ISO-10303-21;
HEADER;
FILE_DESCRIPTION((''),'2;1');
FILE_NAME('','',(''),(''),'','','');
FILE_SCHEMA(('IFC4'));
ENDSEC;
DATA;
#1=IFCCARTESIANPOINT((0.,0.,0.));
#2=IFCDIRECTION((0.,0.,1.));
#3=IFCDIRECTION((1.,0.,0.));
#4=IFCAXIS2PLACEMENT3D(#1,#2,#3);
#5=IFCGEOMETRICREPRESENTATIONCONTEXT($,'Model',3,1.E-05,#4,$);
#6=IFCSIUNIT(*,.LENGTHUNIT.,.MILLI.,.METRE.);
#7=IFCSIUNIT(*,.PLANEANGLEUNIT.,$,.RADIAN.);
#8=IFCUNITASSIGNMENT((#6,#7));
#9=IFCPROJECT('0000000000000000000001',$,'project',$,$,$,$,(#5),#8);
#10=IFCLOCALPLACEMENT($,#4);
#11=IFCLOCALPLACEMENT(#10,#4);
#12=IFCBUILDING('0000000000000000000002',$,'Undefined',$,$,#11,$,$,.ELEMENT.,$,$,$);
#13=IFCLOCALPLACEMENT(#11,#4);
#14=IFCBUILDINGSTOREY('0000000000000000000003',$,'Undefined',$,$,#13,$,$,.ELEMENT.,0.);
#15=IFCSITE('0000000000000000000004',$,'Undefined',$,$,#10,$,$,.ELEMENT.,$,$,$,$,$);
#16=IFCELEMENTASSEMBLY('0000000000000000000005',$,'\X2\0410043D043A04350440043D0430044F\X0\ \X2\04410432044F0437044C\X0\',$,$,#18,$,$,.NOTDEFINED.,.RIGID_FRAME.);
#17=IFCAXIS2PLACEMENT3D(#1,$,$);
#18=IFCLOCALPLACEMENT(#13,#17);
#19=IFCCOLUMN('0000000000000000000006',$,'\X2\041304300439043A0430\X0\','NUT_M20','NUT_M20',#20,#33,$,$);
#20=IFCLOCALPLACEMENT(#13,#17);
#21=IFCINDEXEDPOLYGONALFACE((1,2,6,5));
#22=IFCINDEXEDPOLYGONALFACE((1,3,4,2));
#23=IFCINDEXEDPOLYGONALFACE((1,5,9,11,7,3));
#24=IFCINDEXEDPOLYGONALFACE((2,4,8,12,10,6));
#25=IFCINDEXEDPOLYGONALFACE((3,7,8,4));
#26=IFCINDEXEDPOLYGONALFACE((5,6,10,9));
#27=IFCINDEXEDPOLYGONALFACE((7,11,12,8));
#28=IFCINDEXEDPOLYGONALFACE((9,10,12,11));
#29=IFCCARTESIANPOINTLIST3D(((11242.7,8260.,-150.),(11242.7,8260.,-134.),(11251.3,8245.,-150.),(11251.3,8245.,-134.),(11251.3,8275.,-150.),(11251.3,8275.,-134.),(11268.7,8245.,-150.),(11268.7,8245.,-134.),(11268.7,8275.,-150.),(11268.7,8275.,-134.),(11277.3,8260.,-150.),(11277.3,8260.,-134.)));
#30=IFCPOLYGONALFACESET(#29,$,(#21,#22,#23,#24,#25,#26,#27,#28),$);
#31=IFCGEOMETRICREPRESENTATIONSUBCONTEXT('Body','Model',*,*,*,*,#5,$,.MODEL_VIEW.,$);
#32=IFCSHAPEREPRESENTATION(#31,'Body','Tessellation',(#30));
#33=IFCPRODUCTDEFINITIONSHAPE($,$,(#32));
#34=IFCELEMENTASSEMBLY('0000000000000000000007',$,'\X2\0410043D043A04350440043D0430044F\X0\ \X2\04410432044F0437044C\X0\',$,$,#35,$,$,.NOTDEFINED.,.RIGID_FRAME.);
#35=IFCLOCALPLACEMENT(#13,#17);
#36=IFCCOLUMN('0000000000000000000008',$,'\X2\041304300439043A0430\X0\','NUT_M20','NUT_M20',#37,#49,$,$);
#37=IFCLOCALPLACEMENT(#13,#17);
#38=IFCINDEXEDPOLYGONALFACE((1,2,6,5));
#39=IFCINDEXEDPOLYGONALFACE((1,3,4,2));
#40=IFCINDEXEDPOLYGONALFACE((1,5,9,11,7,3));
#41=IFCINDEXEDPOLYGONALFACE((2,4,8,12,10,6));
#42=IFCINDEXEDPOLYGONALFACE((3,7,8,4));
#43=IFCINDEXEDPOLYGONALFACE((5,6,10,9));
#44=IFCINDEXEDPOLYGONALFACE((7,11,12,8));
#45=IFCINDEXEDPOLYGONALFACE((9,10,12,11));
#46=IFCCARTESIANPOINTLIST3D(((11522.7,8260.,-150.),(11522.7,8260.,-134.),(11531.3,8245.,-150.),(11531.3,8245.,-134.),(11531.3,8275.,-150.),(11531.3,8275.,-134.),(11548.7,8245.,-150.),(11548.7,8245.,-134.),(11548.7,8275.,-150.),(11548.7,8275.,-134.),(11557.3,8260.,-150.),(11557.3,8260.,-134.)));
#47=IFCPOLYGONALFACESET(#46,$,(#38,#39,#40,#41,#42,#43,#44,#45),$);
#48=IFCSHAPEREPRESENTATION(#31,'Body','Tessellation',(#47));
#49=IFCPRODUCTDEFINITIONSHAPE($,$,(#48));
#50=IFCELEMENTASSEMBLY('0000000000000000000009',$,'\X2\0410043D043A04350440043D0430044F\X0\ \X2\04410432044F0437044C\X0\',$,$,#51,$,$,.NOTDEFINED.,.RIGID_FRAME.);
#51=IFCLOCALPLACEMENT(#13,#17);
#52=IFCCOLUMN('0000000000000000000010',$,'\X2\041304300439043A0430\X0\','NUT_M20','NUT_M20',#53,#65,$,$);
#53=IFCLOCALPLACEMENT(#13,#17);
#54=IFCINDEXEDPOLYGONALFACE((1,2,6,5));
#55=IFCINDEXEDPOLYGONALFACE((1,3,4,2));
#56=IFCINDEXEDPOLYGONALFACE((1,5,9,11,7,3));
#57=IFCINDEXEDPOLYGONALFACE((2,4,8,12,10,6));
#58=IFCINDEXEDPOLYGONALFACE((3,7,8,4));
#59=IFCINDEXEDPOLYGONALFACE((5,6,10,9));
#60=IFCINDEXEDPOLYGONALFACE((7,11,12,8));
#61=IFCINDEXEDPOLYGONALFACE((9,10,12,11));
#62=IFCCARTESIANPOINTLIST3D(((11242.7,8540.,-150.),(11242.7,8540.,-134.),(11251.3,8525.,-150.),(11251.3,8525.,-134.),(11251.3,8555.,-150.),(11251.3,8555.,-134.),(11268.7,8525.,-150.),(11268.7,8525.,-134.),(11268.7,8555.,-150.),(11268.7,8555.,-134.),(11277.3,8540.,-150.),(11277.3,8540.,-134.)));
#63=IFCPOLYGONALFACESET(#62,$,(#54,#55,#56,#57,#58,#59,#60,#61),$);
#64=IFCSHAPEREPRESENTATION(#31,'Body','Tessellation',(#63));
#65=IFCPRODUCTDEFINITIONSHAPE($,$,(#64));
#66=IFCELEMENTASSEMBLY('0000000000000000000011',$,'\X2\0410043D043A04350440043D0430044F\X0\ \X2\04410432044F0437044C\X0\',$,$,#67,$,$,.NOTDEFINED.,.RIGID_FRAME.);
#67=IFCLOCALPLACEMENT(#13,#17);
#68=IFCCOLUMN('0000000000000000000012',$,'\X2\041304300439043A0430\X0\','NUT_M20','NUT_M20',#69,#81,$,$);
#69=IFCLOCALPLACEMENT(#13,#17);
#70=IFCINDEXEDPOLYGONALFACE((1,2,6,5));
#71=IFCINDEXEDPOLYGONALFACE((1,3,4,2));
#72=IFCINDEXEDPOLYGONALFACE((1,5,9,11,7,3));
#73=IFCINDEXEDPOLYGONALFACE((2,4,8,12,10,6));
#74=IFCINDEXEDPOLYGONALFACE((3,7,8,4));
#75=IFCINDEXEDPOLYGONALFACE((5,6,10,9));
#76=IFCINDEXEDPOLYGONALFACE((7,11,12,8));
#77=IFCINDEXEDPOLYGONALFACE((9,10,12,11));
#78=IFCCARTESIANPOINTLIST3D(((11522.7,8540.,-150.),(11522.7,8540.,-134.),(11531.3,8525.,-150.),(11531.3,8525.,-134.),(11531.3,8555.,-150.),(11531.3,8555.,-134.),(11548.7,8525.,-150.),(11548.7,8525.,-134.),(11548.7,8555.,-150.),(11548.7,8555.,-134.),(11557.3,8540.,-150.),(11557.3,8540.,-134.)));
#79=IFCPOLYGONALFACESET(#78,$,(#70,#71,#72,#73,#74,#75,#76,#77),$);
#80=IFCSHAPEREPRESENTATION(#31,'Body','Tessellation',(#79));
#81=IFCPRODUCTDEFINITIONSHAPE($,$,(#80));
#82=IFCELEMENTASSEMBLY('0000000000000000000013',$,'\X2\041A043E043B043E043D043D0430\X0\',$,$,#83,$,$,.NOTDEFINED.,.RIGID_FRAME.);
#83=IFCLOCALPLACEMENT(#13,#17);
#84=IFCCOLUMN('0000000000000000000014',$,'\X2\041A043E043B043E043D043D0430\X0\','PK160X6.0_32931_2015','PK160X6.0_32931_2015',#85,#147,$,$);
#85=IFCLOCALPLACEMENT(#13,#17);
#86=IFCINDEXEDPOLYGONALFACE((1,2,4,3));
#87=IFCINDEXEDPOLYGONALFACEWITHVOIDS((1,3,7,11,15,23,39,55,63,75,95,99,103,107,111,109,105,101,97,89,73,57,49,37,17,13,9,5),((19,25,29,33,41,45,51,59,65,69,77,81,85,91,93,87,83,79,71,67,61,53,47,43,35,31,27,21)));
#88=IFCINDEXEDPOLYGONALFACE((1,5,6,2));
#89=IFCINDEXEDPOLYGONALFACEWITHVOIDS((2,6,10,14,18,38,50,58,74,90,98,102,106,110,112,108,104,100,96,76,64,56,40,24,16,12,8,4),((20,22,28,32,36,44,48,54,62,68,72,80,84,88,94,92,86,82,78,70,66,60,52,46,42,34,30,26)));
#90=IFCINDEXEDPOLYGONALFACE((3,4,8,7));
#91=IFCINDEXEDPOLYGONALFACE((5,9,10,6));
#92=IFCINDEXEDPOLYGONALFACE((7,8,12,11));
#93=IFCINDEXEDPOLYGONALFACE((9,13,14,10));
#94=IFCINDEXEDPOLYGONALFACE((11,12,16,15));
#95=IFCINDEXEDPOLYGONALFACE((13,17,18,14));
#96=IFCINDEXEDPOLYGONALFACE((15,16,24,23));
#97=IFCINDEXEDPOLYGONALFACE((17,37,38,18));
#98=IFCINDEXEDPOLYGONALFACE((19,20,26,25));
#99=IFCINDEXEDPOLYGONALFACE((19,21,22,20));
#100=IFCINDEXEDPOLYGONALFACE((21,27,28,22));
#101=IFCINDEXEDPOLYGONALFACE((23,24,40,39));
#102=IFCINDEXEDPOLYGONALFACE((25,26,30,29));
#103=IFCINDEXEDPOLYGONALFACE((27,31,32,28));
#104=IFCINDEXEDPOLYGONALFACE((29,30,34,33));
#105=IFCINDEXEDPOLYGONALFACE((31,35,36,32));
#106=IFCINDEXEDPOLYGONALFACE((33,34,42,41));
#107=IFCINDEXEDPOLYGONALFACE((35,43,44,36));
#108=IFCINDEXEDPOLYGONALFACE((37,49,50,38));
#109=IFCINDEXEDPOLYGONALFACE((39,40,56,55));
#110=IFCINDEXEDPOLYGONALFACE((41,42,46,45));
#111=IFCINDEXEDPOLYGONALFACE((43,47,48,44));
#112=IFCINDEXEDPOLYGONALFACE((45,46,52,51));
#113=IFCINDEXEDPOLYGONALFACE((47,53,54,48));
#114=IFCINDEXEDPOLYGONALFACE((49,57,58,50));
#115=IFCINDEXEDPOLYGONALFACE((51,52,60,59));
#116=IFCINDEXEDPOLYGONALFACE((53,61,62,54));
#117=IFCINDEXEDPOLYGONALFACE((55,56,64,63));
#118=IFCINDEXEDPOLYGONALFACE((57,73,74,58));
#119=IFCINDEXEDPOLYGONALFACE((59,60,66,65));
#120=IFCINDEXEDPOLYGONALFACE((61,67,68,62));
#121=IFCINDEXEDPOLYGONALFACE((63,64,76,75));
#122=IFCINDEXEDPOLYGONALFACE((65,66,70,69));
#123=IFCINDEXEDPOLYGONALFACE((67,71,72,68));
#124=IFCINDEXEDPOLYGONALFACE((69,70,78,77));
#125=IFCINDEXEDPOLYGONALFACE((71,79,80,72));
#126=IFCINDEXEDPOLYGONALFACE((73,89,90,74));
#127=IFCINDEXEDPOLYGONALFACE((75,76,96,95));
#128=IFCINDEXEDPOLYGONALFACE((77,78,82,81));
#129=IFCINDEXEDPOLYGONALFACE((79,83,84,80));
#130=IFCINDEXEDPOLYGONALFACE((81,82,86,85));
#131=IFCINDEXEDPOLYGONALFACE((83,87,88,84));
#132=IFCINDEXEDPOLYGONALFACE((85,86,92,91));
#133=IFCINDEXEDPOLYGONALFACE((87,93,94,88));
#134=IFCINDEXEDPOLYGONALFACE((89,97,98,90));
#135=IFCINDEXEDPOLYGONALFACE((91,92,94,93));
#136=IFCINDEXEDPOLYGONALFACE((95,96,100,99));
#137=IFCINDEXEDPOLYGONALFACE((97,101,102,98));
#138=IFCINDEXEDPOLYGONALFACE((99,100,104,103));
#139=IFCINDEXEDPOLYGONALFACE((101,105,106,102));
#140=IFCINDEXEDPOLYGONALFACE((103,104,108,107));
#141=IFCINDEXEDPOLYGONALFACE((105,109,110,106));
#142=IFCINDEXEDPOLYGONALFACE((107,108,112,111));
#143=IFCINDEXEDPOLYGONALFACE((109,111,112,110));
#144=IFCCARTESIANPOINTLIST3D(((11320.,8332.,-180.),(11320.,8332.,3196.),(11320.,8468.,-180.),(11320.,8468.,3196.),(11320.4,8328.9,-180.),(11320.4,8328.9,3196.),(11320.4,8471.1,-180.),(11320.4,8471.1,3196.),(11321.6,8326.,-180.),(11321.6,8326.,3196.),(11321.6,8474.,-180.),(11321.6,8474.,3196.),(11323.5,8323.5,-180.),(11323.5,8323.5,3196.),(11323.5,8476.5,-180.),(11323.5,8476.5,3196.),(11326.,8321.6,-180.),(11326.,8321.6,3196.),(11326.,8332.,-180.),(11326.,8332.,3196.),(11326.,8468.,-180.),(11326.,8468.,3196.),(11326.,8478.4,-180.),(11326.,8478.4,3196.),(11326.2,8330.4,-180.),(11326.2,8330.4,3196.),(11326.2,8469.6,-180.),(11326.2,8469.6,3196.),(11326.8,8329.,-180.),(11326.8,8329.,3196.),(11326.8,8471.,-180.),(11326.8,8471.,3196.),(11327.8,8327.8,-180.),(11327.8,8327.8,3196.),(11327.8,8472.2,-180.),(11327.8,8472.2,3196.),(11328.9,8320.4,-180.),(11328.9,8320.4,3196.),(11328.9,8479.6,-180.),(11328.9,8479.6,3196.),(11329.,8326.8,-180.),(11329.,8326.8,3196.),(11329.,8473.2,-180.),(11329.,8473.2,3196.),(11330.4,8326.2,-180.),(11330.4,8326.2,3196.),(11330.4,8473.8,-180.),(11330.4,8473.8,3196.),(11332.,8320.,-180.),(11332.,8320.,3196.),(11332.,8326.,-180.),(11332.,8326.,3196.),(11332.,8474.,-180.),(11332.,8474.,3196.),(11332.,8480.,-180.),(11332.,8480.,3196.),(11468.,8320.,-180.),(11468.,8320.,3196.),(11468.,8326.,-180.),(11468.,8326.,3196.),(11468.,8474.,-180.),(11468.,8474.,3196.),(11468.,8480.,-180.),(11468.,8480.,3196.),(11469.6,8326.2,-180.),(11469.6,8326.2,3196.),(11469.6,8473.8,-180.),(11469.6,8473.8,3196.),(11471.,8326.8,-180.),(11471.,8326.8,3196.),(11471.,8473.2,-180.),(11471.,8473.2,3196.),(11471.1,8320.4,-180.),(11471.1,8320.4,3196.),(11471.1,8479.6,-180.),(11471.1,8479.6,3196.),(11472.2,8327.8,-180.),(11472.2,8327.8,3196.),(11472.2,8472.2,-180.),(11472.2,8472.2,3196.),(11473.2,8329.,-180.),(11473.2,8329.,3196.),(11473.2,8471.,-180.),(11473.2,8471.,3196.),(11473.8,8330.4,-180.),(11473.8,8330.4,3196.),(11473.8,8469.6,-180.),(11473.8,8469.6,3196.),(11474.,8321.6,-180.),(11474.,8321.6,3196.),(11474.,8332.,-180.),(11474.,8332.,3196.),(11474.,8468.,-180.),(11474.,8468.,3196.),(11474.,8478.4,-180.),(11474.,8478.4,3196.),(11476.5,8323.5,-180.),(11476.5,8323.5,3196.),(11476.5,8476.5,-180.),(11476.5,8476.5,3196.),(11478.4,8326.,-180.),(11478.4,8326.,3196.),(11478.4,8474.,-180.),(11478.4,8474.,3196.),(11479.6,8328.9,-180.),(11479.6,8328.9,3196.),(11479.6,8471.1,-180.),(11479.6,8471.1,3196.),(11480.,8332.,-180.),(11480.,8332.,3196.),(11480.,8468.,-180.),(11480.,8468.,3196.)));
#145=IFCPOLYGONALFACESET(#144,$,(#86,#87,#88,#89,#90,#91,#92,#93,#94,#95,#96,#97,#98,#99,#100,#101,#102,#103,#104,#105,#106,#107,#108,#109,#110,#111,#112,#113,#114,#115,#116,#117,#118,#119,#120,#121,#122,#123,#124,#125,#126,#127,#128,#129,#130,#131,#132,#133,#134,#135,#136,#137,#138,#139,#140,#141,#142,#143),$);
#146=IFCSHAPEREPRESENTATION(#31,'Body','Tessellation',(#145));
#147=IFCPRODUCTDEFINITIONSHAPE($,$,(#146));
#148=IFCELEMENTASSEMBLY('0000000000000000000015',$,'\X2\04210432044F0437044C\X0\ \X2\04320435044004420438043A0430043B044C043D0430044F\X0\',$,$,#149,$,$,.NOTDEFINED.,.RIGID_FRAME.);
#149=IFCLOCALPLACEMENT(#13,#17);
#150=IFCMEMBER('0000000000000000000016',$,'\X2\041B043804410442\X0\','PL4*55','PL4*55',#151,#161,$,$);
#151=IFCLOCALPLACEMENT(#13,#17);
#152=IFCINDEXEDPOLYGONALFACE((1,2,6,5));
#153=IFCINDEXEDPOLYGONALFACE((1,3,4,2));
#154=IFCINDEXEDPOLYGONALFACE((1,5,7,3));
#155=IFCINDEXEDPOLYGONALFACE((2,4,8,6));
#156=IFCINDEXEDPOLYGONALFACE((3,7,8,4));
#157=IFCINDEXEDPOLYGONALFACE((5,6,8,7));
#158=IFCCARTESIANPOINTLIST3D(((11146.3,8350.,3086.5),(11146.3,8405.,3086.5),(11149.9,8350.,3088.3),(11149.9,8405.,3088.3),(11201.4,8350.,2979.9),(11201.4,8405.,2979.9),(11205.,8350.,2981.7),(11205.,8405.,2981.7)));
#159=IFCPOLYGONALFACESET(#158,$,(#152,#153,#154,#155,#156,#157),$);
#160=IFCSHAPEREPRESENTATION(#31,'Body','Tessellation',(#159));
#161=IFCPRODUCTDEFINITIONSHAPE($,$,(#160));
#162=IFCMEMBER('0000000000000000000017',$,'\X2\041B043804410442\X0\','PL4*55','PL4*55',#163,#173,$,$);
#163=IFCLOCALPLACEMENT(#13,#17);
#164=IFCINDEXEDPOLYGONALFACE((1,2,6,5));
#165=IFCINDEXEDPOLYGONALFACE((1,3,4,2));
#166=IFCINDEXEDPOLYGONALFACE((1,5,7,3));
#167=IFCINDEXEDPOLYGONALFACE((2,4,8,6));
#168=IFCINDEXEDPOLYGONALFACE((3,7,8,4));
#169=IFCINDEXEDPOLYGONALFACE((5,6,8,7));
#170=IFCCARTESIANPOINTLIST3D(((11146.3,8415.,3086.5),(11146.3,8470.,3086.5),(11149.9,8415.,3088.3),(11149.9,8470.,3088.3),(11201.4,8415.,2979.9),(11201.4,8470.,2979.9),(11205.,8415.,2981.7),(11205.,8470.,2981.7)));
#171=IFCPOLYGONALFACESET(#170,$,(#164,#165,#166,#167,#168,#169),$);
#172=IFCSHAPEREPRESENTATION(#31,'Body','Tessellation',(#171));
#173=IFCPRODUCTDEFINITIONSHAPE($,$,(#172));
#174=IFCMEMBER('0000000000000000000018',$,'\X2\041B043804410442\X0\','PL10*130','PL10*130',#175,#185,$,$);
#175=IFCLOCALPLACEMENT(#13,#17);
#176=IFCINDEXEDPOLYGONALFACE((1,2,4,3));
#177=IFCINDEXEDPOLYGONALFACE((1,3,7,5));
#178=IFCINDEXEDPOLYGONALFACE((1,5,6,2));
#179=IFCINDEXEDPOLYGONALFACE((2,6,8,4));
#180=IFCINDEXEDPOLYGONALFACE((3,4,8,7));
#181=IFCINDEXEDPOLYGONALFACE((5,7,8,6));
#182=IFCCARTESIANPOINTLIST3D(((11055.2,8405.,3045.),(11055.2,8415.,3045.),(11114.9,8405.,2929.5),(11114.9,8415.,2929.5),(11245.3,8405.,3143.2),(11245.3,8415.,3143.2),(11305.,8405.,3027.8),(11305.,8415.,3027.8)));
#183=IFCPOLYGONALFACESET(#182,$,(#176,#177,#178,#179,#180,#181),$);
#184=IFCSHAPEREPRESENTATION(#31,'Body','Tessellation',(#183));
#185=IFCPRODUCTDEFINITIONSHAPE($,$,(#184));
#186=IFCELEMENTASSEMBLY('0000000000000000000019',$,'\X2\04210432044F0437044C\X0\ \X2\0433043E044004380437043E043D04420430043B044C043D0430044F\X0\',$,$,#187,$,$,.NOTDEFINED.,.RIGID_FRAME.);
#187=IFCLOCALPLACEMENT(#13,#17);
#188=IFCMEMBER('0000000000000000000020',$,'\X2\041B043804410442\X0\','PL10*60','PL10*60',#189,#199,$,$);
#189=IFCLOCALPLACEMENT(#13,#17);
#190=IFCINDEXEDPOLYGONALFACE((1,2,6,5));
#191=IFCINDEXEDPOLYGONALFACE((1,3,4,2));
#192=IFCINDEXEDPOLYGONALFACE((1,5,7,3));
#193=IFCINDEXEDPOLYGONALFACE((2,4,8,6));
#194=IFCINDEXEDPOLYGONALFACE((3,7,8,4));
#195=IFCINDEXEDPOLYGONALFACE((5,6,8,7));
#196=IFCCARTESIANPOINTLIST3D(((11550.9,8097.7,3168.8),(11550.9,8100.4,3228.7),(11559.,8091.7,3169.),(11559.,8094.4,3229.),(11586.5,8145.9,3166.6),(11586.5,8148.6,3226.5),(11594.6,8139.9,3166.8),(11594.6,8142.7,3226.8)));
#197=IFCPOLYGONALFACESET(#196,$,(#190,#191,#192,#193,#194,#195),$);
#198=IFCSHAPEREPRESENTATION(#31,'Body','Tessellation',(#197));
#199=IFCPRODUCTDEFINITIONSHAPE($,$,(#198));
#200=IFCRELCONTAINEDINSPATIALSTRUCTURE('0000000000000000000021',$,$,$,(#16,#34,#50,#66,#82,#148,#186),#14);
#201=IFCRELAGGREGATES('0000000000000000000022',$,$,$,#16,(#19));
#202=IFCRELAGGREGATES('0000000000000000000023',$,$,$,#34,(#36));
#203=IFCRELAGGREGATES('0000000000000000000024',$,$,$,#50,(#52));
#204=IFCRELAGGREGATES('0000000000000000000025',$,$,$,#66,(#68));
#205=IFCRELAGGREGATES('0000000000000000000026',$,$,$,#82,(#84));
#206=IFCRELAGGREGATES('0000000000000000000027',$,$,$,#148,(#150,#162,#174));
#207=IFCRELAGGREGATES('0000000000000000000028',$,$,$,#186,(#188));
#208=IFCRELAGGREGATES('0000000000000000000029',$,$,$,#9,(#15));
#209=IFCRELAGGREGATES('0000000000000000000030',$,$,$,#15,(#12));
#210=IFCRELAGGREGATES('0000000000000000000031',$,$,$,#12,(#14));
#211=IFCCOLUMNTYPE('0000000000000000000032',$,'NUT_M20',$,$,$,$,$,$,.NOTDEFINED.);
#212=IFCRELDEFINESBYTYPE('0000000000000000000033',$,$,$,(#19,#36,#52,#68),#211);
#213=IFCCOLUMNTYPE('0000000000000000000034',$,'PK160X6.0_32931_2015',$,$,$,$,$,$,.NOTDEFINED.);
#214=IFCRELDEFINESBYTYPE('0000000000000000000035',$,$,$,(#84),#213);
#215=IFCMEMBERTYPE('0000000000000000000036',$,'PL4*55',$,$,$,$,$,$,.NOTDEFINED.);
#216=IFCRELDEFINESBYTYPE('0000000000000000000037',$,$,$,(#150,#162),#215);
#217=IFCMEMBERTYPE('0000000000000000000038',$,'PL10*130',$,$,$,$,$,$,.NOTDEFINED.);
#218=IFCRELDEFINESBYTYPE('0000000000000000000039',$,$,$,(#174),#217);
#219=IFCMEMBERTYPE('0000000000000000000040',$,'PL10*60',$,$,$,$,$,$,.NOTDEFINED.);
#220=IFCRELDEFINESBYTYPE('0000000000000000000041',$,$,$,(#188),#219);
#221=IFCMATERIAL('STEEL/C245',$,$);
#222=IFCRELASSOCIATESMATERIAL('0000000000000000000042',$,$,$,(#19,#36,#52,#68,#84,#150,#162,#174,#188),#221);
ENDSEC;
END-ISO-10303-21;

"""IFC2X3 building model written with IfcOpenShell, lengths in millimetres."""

from ifc_helpers import new_model, si_unit, frame, origin_with_axes, origin_2d_with_axis, place, context, subcontext, project, spatial, polyline, rectangle, hollow_rectangle, outline, extrude, clip, halfspace, material, type_object, element, aggregate, save


model = new_model("IFC2X3")

# Units and contexts
model_context = context("Model", 3, precision=1e-05, world=origin_with_axes())
body_context = subcontext(model_context, "Body", "Model", "MODEL_VIEW")
ifc_project = project(units=[si_unit("LENGTHUNIT", "METRE", prefix="MILLI"), si_unit("PLANEANGLEUNIT", "RADIAN")], contexts=[model_context])

# Site, building, storey
site_placement = place(None, origin_with_axes())
site = spatial("IfcSite", under=ifc_project, at=site_placement, Name="Undefined", CompositionType="ELEMENT")
building_placement = place(site_placement, origin_with_axes())
building = spatial("IfcBuilding", under=site, at=building_placement, Name="Undefined", CompositionType="ELEMENT")
storey_placement = place(building_placement, origin_with_axes())
storey = spatial("IfcBuildingStorey", under=building, at=storey_placement, Name="Undefined", CompositionType="ELEMENT", Elevation=0.0)

# Element assemblies, columns
assembly_1_placement = place(storey_placement, origin_with_axes())
assembly_1 = element("IfcElementAssembly", 1, at=assembly_1_placement, inside=storey, Name="Анкерная связь", AssemblyPlace="NOTDEFINED", PredefinedType="RIGID_FRAME")
ifc_material_1 = material(Name="STEEL/C245")
column_type_1 = type_object("IfcColumnType", Name="NUT_M20", PredefinedType="NOTDEFINED")
column_1_placement = place(assembly_1_placement, frame((11260.0, 8260.0, -134.0), z_axis=(0.0, 0.0, -1.0), x_axis=(0.0, -1.0, 0.0)))
column_1 = element("IfcColumn", 2, at=column_1_placement, type_object=column_type_1, material=ifc_material_1, Name="Гайка", Description="NUT_M20", ObjectType="NUT_M20", context=body_context, shape_type="SweptSolid", body=[
    extrude(outline(polyline([(8.7, -15.0), (-8.7, -15.0), (-17.3, 0.0), (-8.7, 15.0), (8.7, 15.0), (17.3, 0.0), (8.7, -15.0)])), frame((0.0, 0.0, 16.0), z_axis=(0.0, 0.0, -1.0), x_axis=(0.0, 1.0, 0.0)), (0.0, 0.0, 1.0), 16.0),
])
aggregate(assembly_1, [column_1])
assembly_2_placement = place(storey_placement, origin_with_axes())
assembly_2 = element("IfcElementAssembly", 3, at=assembly_2_placement, inside=storey, Name="Анкерная связь", AssemblyPlace="NOTDEFINED", PredefinedType="RIGID_FRAME")
column_2_placement = place(assembly_2_placement, frame((11540.0, 8260.0, -134.0), z_axis=(0.0, 0.0, -1.0), x_axis=(0.0, 1.0, 0.0)))
column_2 = element("IfcColumn", 4, at=column_2_placement, type_object=column_type_1, material=ifc_material_1, Name="Гайка", Description="NUT_M20", ObjectType="NUT_M20", context=body_context, shape_type="SweptSolid", body=[
    extrude(outline(polyline([(8.7, -15.0), (-8.7, -15.0), (-17.3, 0.0), (-8.7, 15.0), (8.7, 15.0), (17.3, 0.0), (8.7, -15.0)])), frame((0.0, 0.0, 16.0), z_axis=(0.0, 0.0, -1.0), x_axis=(0.0, 1.0, 0.0)), (0.0, 0.0, 1.0), 16.0),
])
aggregate(assembly_2, [column_2])
assembly_3_placement = place(storey_placement, origin_with_axes())
assembly_3 = element("IfcElementAssembly", 5, at=assembly_3_placement, inside=storey, Name="Анкерная связь", AssemblyPlace="NOTDEFINED", PredefinedType="RIGID_FRAME")
column_3_placement = place(assembly_3_placement, frame((11260.0, 8540.0, -134.0), z_axis=(0.0, 0.0, -1.0), x_axis=(0.0, -1.0, 0.0)))
column_3 = element("IfcColumn", 6, at=column_3_placement, type_object=column_type_1, material=ifc_material_1, Name="Гайка", Description="NUT_M20", ObjectType="NUT_M20", context=body_context, shape_type="SweptSolid", body=[
    extrude(outline(polyline([(8.7, -15.0), (-8.7, -15.0), (-17.3, 0.0), (-8.7, 15.0), (8.7, 15.0), (17.3, 0.0), (8.7, -15.0)])), frame((0.0, 0.0, 16.0), z_axis=(0.0, 0.0, -1.0), x_axis=(0.0, 1.0, 0.0)), (0.0, 0.0, 1.0), 16.0),
])
aggregate(assembly_3, [column_3])
assembly_4_placement = place(storey_placement, origin_with_axes())
assembly_4 = element("IfcElementAssembly", 7, at=assembly_4_placement, inside=storey, Name="Анкерная связь", AssemblyPlace="NOTDEFINED", PredefinedType="RIGID_FRAME")
column_4_placement = place(assembly_4_placement, frame((11540.0, 8540.0, -134.0), z_axis=(0.0, 0.0, -1.0), x_axis=(0.0, 1.0, 0.0)))
column_4 = element("IfcColumn", 8, at=column_4_placement, type_object=column_type_1, material=ifc_material_1, Name="Гайка", Description="NUT_M20", ObjectType="NUT_M20", context=body_context, shape_type="SweptSolid", body=[
    extrude(outline(polyline([(8.7, -15.0), (-8.7, -15.0), (-17.3, 0.0), (-8.7, 15.0), (8.7, 15.0), (17.3, 0.0), (8.7, -15.0)])), frame((0.0, 0.0, 16.0), z_axis=(0.0, 0.0, -1.0), x_axis=(0.0, 1.0, 0.0)), (0.0, 0.0, 1.0), 16.0),
])
aggregate(assembly_4, [column_4])
assembly_5_placement = place(storey_placement, origin_with_axes())
assembly_5 = element("IfcElementAssembly", 9, at=assembly_5_placement, inside=storey, Name="Колонна", AssemblyPlace="NOTDEFINED", PredefinedType="RIGID_FRAME")
column_type_2 = type_object("IfcColumnType", Name="PK160X6.0_32931_2015", PredefinedType="NOTDEFINED")
column_5_placement = place(assembly_5_placement, frame((11400.0, 8400.0, -40.0), z_axis=(0.0, 0.0, 1.0), x_axis=(0.0, 1.0, 0.0)))
column_5 = element("IfcColumn", 10, at=column_5_placement, type_object=column_type_2, material=ifc_material_1, Name="Колонна", Description="PK160X6.0_32931_2015", ObjectType="PK160X6.0_32931_2015", context=body_context, shape_type="Clipping", body=[
    clip(clip(extrude(hollow_rectangle(XDim=160.0, YDim=160.0, WallThickness=6.0, InnerFilletRadius=6.0, OuterFilletRadius=12.0, at=origin_2d_with_axis()), frame((0.0, 0.0, 3236.0), z_axis=(0.0, 0.0, -1.0), x_axis=(0.0, 1.0, 0.0)), (0.0, 0.0, 1.0), 3376.0), halfspace(frame((-80.0, 0.0, 3236.0), z_axis=(0.0, 0.0, -1.0), x_axis=(0.0, -1.0, 0.0)), True)), halfspace(frame((-80.0, 0.0, -140.0), z_axis=(0.0, 0.0, 1.0), x_axis=(0.0, 1.0, 0.0)), True)),
])

# Element assembly, members
assembly_6_placement = place(storey_placement, origin_with_axes())
assembly_6 = element("IfcElementAssembly", 11, at=assembly_6_placement, inside=storey, Name="Связь вертикальная", AssemblyPlace="NOTDEFINED", PredefinedType="RIGID_FRAME")
member_type_1 = type_object("IfcMemberType", Name="PL4*55", PredefinedType="NOTDEFINED")
member_1_placement = place(assembly_6_placement, frame((11203.2, 8377.5, 2980.8), z_axis=(0.0, 1.0, 0.0), x_axis=(-0.45902, 0.0, 0.888426)))
member_1 = element("IfcMember", 12, at=member_1_placement, type_object=member_type_1, material=ifc_material_1, Name="Лист", Description="PL4*55", ObjectType="PL4*55", context=body_context, shape_type="SweptSolid", body=[
    extrude(rectangle(XDim=4.0, YDim=55.0, at=origin_2d_with_axis()), frame((120.0, 0.0, 0.0), z_axis=(-1.0, 0.0, 0.0), x_axis=(0.0, -1.0, 0.0)), (0.0, 0.0, 1.0), 120.0),
])
member_2_placement = place(assembly_6_placement, frame((11203.2, 8442.5, 2980.8), z_axis=(0.0, -1.0, 0.0), x_axis=(-0.45902, 0.0, 0.888426)))
member_2 = element("IfcMember", 13, at=member_2_placement, type_object=member_type_1, material=ifc_material_1, Name="Лист", Description="PL4*55", ObjectType="PL4*55", context=body_context, shape_type="SweptSolid", body=[
    extrude(rectangle(XDim=4.0, YDim=55.0, at=origin_2d_with_axis()), frame((120.0, 0.0, 0.0), z_axis=(-1.0, 0.0, 0.0), x_axis=(0.0, -1.0, 0.0)), (0.0, 0.0, 1.0), 120.0),
])
member_type_2 = type_object("IfcMemberType", Name="PL10*130", PredefinedType="NOTDEFINED")
member_3_placement = place(assembly_6_placement, frame((11275.2, 8410.0, 3085.5), z_axis=(0.45902, 0.0, -0.888426), x_axis=(-0.888426, 0.0, -0.45902)))
member_3 = element("IfcMember", 14, at=member_3_placement, type_object=member_type_2, material=ifc_material_1, Name="Лист", Description="PL10*130", ObjectType="PL10*130", context=body_context, shape_type="SweptSolid", body=[
    extrude(rectangle(XDim=10.0, YDim=130.0, at=origin_2d_with_axis()), frame((214.0, 0.0, 0.0), z_axis=(-1.0, 0.0, 0.0), x_axis=(0.0, -1.0, 0.0)), (0.0, 0.0, 1.0), 214.0),
])

# Element assembly, member
assembly_7_placement = place(storey_placement, origin_with_axes())
assembly_7 = element("IfcElementAssembly", 15, at=assembly_7_placement, inside=storey, Name="Связь горизонтальная", AssemblyPlace="NOTDEFINED", PredefinedType="RIGID_FRAME")
member_type_3 = type_object("IfcMemberType", Name="PL10*60", PredefinedType="NOTDEFINED")
member_4_placement = place(assembly_7_placement, frame((11572.7, 8121.5, 3227.7), z_axis=(-0.593795, -0.803786, 0.036536), x_axis=(0.0, -0.045408, -0.998969)))
member_4 = element("IfcMember", 16, at=member_4_placement, type_object=member_type_3, material=ifc_material_1, Name="Лист", Description="PL10*60", ObjectType="PL10*60", context=body_context, shape_type="SweptSolid", body=[
    extrude(rectangle(XDim=10.0, YDim=60.0, at=origin_2d_with_axis()), frame((60.0, 0.0, 0.0), z_axis=(-1.0, 0.0, 0.0), x_axis=(0.0, -1.0, 0.0)), (0.0, 0.0, 1.0), 60.0),
])

aggregate(assembly_5, [column_5])

aggregate(assembly_6, [member_1, member_2, member_3])
aggregate(assembly_7, [member_4])

save(model, "model.ifc")
